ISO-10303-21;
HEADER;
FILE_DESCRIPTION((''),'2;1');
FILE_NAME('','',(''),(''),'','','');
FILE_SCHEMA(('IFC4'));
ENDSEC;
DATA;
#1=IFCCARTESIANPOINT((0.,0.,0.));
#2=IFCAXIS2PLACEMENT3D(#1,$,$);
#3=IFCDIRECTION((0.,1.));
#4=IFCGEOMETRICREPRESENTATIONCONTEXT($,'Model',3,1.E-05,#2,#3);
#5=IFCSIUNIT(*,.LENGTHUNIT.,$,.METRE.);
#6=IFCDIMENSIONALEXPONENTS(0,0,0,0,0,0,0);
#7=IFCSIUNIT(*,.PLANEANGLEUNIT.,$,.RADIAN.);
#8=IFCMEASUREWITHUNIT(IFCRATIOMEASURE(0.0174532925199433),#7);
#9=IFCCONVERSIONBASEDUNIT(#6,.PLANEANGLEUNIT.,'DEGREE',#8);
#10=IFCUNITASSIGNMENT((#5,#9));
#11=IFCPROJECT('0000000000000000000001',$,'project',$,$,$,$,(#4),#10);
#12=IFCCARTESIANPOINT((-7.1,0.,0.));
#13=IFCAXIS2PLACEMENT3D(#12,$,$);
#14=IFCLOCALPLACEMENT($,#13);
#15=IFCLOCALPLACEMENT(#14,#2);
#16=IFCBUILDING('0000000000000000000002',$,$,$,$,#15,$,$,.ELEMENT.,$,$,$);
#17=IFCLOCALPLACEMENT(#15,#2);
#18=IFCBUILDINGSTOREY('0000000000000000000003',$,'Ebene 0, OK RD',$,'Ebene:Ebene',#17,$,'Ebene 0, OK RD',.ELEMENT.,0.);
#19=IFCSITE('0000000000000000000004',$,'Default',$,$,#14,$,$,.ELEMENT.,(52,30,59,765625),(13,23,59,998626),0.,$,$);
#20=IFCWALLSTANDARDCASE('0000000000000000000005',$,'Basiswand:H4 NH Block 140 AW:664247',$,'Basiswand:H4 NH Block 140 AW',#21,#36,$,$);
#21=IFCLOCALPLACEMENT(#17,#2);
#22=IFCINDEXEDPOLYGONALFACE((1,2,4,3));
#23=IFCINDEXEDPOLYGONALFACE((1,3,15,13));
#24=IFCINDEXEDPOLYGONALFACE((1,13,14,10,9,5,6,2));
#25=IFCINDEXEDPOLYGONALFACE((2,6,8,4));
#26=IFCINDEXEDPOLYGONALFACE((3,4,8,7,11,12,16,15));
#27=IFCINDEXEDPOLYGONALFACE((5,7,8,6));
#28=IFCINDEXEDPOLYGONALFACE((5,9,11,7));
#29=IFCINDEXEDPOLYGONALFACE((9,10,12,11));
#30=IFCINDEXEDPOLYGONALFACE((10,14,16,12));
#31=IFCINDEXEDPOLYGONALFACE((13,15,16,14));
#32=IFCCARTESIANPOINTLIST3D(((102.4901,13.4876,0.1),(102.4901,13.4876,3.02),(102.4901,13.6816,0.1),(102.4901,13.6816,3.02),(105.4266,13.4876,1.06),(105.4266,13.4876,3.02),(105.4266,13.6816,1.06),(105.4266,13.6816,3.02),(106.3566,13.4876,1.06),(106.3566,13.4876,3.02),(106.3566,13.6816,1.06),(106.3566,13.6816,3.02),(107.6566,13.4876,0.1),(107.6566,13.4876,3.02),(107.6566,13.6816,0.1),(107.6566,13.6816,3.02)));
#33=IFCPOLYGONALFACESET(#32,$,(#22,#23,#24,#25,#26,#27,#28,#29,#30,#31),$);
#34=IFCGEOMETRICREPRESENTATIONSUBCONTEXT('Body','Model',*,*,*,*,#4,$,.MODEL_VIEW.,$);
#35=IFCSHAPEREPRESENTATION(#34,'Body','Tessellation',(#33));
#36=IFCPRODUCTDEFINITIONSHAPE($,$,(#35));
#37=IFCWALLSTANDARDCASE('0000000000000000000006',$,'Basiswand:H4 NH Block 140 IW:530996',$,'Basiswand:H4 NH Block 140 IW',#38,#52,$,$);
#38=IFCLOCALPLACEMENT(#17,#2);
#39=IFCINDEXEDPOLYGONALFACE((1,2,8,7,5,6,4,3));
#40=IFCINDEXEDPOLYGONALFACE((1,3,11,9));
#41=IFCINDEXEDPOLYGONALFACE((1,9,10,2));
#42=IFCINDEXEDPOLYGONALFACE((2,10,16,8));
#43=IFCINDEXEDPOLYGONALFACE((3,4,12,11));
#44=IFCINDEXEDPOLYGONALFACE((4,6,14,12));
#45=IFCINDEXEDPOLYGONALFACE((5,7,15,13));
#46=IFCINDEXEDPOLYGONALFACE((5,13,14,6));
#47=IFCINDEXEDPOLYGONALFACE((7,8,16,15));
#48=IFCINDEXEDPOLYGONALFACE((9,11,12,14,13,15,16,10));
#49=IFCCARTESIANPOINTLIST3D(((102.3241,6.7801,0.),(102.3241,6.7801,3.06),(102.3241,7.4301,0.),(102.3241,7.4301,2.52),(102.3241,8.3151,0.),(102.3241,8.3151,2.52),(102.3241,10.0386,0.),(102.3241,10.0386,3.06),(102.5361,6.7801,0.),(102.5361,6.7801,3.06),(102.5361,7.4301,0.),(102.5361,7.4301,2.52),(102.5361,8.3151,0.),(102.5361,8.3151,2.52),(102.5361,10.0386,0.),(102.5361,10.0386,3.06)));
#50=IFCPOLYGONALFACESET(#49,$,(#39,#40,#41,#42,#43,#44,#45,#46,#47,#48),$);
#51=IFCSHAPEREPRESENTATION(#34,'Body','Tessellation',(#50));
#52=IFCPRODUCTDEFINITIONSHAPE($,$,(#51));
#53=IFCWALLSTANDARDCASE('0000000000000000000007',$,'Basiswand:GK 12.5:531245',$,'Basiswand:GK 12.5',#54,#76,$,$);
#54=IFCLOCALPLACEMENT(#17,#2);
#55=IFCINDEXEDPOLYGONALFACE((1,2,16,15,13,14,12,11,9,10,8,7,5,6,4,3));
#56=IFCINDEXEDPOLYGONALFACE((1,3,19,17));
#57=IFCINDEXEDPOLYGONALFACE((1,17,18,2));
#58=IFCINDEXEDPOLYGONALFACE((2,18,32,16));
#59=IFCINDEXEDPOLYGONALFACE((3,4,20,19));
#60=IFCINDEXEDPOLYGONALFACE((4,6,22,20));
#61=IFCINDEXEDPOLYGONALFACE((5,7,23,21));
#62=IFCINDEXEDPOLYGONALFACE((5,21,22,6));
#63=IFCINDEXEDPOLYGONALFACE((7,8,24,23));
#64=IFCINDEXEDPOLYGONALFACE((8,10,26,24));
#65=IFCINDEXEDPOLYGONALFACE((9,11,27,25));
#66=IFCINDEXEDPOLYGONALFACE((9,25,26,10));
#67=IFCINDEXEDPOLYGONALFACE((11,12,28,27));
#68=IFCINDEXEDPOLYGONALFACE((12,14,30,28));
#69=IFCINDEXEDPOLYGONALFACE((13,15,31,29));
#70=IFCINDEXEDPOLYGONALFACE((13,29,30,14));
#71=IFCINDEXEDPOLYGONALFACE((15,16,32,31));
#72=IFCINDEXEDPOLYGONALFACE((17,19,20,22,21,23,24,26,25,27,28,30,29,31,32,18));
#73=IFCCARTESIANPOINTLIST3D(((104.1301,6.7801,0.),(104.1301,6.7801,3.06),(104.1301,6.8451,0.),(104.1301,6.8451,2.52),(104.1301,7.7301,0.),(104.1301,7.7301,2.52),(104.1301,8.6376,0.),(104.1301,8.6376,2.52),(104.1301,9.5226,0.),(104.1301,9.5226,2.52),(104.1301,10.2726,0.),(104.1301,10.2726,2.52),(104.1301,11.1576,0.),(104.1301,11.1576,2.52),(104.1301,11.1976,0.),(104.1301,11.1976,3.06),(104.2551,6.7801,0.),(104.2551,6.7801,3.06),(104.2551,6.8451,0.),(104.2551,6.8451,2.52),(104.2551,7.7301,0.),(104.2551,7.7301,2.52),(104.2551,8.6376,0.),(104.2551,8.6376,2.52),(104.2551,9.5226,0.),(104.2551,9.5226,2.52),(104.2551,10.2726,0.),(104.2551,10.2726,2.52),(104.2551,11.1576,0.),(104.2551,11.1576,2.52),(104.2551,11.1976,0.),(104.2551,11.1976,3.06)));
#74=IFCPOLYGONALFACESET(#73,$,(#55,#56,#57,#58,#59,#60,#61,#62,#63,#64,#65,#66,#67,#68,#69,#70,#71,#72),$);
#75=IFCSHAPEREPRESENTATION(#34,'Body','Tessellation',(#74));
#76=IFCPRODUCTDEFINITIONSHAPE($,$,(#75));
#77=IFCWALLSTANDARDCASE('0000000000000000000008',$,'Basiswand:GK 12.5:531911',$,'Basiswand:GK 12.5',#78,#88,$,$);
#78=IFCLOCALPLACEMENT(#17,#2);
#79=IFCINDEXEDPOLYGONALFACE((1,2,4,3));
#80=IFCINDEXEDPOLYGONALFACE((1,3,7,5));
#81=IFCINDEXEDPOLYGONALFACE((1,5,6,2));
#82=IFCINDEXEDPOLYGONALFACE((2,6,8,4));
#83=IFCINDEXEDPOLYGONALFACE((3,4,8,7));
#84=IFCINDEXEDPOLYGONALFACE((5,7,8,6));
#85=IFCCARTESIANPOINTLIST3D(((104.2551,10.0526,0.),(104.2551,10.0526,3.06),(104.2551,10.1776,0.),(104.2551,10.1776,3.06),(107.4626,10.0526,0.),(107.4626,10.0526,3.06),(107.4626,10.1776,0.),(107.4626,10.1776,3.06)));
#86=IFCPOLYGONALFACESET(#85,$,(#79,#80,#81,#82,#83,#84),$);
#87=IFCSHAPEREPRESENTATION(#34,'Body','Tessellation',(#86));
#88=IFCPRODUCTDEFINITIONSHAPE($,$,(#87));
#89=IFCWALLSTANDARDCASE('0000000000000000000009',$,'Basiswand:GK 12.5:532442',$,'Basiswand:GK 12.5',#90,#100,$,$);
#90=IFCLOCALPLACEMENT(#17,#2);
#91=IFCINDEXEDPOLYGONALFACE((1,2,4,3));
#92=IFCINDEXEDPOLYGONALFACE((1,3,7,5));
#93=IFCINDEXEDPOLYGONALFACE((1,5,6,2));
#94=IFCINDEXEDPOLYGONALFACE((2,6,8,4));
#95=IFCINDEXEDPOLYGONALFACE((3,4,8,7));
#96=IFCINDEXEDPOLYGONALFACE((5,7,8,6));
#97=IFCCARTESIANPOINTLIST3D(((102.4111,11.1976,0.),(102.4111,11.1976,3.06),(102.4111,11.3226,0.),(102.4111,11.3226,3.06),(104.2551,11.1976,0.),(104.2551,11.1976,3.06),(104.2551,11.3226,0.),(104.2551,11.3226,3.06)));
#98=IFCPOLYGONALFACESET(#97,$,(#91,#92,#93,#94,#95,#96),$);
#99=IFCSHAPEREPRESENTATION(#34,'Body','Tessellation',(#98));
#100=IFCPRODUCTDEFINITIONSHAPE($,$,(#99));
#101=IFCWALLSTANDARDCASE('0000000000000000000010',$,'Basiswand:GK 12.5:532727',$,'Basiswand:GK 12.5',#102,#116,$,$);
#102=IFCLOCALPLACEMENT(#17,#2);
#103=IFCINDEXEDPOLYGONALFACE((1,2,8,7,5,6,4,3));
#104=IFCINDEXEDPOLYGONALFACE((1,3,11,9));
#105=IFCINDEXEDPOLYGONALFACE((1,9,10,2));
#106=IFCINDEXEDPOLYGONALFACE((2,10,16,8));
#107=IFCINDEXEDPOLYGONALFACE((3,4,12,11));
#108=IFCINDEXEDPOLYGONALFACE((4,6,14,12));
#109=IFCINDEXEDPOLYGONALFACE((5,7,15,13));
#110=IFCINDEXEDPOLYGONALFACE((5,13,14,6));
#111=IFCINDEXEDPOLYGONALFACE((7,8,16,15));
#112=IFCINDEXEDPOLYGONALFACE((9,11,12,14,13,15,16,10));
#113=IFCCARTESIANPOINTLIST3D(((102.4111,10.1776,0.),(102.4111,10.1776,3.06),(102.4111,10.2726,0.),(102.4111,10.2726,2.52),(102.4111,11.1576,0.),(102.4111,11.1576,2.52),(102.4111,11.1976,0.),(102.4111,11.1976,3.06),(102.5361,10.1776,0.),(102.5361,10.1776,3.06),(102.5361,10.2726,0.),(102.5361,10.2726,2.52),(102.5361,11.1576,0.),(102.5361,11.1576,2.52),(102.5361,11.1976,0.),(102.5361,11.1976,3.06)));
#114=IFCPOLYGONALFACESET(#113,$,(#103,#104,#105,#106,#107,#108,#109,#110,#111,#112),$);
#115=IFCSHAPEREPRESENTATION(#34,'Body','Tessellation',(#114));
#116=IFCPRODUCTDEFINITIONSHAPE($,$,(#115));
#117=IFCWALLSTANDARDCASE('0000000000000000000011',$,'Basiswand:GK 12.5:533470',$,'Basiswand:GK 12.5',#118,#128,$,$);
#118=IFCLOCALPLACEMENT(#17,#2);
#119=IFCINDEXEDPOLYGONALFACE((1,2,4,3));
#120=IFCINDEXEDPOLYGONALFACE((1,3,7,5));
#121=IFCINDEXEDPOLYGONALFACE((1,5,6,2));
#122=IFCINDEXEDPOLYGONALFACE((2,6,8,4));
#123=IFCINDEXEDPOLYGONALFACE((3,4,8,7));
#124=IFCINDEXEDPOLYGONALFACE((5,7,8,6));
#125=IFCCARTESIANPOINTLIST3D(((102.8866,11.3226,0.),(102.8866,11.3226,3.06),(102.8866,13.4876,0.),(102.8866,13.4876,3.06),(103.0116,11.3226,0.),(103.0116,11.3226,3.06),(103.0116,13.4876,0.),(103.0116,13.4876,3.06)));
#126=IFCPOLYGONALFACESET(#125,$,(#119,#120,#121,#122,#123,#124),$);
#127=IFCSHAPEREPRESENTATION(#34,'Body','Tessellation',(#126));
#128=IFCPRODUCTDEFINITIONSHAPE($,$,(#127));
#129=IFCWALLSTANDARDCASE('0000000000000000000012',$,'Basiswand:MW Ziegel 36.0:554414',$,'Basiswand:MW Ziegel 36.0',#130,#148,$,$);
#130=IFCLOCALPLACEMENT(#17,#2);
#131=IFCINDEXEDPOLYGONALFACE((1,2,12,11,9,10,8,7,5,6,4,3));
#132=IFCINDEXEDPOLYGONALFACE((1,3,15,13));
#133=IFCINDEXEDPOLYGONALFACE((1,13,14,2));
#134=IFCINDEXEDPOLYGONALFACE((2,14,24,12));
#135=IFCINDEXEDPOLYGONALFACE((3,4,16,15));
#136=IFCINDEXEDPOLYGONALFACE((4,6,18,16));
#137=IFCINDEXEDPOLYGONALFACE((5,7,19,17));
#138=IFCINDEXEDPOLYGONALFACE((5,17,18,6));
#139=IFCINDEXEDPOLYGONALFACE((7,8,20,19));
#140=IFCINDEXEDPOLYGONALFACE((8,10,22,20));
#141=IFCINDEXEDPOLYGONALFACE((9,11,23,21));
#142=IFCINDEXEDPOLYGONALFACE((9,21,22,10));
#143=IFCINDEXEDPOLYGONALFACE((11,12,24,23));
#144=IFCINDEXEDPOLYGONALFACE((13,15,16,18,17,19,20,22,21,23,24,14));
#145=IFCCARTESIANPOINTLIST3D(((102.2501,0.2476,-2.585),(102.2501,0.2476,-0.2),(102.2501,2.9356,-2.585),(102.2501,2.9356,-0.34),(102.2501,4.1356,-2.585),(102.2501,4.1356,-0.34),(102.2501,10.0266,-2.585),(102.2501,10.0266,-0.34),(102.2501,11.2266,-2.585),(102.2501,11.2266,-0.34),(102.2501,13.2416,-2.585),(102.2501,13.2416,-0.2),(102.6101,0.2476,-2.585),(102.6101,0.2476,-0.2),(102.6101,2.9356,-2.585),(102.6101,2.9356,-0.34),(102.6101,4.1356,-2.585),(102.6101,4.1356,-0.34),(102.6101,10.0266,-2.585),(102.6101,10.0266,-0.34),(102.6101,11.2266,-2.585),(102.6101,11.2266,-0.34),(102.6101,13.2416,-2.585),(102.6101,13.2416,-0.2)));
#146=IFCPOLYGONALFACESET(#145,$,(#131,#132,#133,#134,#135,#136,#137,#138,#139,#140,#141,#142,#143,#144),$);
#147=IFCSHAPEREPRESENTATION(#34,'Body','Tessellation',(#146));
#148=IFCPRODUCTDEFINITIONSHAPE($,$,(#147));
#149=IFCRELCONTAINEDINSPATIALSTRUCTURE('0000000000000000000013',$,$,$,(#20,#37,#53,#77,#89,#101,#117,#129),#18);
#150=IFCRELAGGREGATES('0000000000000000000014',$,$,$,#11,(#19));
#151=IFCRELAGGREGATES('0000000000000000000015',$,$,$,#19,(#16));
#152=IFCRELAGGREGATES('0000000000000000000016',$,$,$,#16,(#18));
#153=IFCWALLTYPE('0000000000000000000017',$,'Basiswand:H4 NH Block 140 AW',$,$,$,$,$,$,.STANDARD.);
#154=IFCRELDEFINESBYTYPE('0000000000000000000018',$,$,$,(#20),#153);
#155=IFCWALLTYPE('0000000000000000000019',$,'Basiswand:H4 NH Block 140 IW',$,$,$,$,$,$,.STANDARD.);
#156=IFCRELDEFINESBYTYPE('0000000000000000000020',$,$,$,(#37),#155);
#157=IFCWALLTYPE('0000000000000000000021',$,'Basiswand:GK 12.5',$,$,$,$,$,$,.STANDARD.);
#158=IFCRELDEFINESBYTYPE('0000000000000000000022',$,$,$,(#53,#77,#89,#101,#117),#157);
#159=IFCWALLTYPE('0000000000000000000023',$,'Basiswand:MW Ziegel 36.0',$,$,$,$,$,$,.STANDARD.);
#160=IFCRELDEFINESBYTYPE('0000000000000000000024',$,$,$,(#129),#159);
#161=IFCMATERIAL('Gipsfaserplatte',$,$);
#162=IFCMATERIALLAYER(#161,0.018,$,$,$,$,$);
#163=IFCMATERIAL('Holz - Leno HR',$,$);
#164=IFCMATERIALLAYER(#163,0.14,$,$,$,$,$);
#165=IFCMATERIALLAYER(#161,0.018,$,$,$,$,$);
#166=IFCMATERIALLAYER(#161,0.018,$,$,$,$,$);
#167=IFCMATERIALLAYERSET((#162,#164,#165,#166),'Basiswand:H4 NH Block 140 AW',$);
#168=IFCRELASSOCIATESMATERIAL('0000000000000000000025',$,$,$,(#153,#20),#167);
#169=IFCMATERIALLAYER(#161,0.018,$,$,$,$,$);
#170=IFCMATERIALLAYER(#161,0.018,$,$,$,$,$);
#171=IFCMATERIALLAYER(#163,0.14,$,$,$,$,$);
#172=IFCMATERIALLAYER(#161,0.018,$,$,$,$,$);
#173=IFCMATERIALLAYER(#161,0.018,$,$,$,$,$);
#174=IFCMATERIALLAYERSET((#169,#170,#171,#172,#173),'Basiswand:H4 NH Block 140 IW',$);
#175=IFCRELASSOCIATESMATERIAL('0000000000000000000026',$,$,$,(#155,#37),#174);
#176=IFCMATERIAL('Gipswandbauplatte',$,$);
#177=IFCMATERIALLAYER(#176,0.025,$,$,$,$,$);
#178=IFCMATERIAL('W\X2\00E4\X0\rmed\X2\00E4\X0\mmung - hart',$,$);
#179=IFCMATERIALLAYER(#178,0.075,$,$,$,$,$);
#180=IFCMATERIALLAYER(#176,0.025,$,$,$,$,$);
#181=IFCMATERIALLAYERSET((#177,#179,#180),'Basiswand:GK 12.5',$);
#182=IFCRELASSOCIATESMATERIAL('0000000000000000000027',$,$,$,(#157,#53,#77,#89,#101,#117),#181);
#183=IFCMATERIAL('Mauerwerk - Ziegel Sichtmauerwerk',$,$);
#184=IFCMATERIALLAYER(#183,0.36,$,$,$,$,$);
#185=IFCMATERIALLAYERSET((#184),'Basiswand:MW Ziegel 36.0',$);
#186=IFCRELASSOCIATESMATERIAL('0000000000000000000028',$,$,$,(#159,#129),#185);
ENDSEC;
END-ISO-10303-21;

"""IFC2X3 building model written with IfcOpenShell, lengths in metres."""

from ifc_helpers import new_model, entity, si_unit, converted_unit, direction, frame, frame_2d, origin, origin_2d_with_axis, place, context, subcontext, project, spatial, rectangle, extrude, material, layer, layer_set, layer_usage, type_object, element, save


model = new_model("IFC2X3")

# Units and contexts
model_context = context("Model", 3, precision=1e-05, world=origin(), true_north=direction((0.0, 1.0)))
body_context = subcontext(model_context, "Body", "Model", "MODEL_VIEW")
ifc_project = project(units=[si_unit("LENGTHUNIT", "METRE"), converted_unit("PLANEANGLEUNIT", "DEGREE", entity("IfcRatioMeasure", 0.0174532925199433), si_unit("PLANEANGLEUNIT", "RADIAN"), dimensions=[0, 0, 0, 0, 0, 0, 0])], contexts=[model_context])

# Site, building, storey
site_placement = place(None, frame((-7.1, 0.0, 0.0)))
site = spatial("IfcSite", under=ifc_project, at=site_placement, Name="Default", CompositionType="ELEMENT", RefLatitude=(52, 30, 59, 765625), RefLongitude=(13, 23, 59, 998626), RefElevation=0.0)
building_placement = place(site_placement, origin())
building = spatial("IfcBuilding", under=site, at=building_placement, CompositionType="ELEMENT")
storey_placement = place(building_placement, origin())
storey = spatial("IfcBuildingStorey", under=building, at=storey_placement, Name="Ebene 0, OK RD", ObjectType="Ebene:Ebene", LongName="Ebene 0, OK RD", CompositionType="ELEMENT", Elevation=0.0)

# Walls, openings
ifc_material_1 = material(Name="Gipsfaserplatte")
ifc_layer_1 = layer(ifc_material_1, 0.018)
ifc_material_2 = material(Name="Holz - Leno HR")
ifc_layer_2 = layer(ifc_material_2, 0.14)
ifc_layer_3 = layer(ifc_material_1, 0.018)
ifc_layer_4 = layer(ifc_material_1, 0.018)
ifc_layer_set_1 = layer_set([ifc_layer_1, ifc_layer_2, ifc_layer_3, ifc_layer_4], Name="Basiswand:H4 NH Block 140 AW")
ifc_layer_usage_1 = layer_usage(ifc_layer_set_1, "AXIS2", "NEGATIVE", 0.097)
wall_type_1 = type_object("IfcWallType", Name="Basiswand:H4 NH Block 140 AW", PredefinedType="STANDARD", material=ifc_layer_set_1)
wall_1_placement = place(storey_placement, frame((102.4901, 13.5846, 0.1)))
wall_1 = element("IfcWallStandardCase", 1, at=wall_1_placement, inside=storey, type_object=wall_type_1, material=ifc_layer_usage_1, Name="Basiswand:H4 NH Block 140 AW:664247", ObjectType="Basiswand:H4 NH Block 140 AW", context=body_context, shape_type="SweptSolid", body=[
    extrude(rectangle(XDim=5.1665, YDim=0.194, at=frame_2d((2.5833, 0.0), x_axis=(-1.0, 0.0))), origin(), (0.0, 0.0, 1.0), 2.92),
])
opening_1_placement = place(wall_1_placement, origin())
element("IfcOpeningElement", 2, at=opening_1_placement, cuts=wall_1, ObjectType="Opening", context=body_context, shape_type="SweptSolid", body=[
    extrude(rectangle(XDim=2.0, YDim=0.93, at=frame_2d((0.0, 0.0), x_axis=(1.0, 0.0))), frame((3.4015, -0.097, 1.96), z_axis=(0.0, 1.0, 0.0), x_axis=(0.0, 0.0, -1.0)), (0.0, 0.0, 1.0), 0.194),
])
ifc_layer_5 = layer(ifc_material_1, 0.018)
ifc_layer_6 = layer(ifc_material_1, 0.018)
ifc_layer_7 = layer(ifc_material_2, 0.14)
ifc_layer_8 = layer(ifc_material_1, 0.018)
ifc_layer_9 = layer(ifc_material_1, 0.018)
ifc_layer_set_2 = layer_set([ifc_layer_5, ifc_layer_6, ifc_layer_7, ifc_layer_8, ifc_layer_9], Name="Basiswand:H4 NH Block 140 IW")
ifc_layer_usage_2 = layer_usage(ifc_layer_set_2, "AXIS2", "NEGATIVE", 0.106)
wall_type_2 = type_object("IfcWallType", Name="Basiswand:H4 NH Block 140 IW", PredefinedType="STANDARD", material=ifc_layer_set_2)
wall_2_placement = place(storey_placement, frame((102.4301, 10.0386, 0.0), z_axis=(0.0, 0.0, 1.0), x_axis=(0.0, -1.0, 0.0)))
wall_2 = element("IfcWallStandardCase", 3, at=wall_2_placement, inside=storey, type_object=wall_type_2, material=ifc_layer_usage_2, Name="Basiswand:H4 NH Block 140 IW:530996", ObjectType="Basiswand:H4 NH Block 140 IW", context=body_context, shape_type="SweptSolid", body=[
    extrude(rectangle(XDim=3.2585, YDim=0.212, at=frame_2d((1.6292, 0.0), x_axis=(-1.0, 0.0))), origin(), (0.0, 0.0, 1.0), 3.06),
])
opening_2_placement = place(wall_2_placement, frame((2.6085, 0.106, 0.0)))
element("IfcOpeningElement", 4, at=opening_2_placement, cuts=wall_2, ObjectType="Opening", context=body_context, shape_type="SweptSolid", body=[
    extrude(rectangle(XDim=2.52, YDim=0.885, at=frame_2d((1.26, 0.4425), x_axis=(1.0, 0.0))), frame((0.0, 0.0, 0.0), z_axis=(0.0, -1.0, 0.0), x_axis=(0.0, 0.0, 1.0)), (0.0, 0.0, 1.0), 0.212),
])

# Wall, openings
ifc_material_3 = material(Name="Gipswandbauplatte")
ifc_layer_10 = layer(ifc_material_3, 0.025)
ifc_material_4 = material(Name="Wärmedämmung - hart")
ifc_layer_11 = layer(ifc_material_4, 0.075)
ifc_layer_12 = layer(ifc_material_3, 0.025)
ifc_layer_set_3 = layer_set([ifc_layer_10, ifc_layer_11, ifc_layer_12], Name="Basiswand:GK 12.5")
ifc_layer_usage_3 = layer_usage(ifc_layer_set_3, "AXIS2", "NEGATIVE", 0.0625)
wall_type_3 = type_object("IfcWallType", Name="Basiswand:GK 12.5", PredefinedType="STANDARD", material=ifc_layer_set_3)
wall_3_placement = place(storey_placement, frame((104.1926, 11.1976, 0.0), z_axis=(0.0, 0.0, 1.0), x_axis=(0.0, -1.0, 0.0)))
wall_3 = element("IfcWallStandardCase", 5, at=wall_3_placement, inside=storey, type_object=wall_type_3, material=ifc_layer_usage_3, Name="Basiswand:GK 12.5:531245", ObjectType="Basiswand:GK 12.5", context=body_context, shape_type="SweptSolid", body=[
    extrude(rectangle(XDim=4.4175, YDim=0.125, at=frame_2d((2.2088, 0.0), x_axis=(-1.0, 0.0))), origin(), (0.0, 0.0, 1.0), 3.06),
])
opening_3_placement = place(wall_3_placement, frame((0.04, -0.0625, 0.0)))
element("IfcOpeningElement", 6, at=opening_3_placement, cuts=wall_3, ObjectType="Opening", context=body_context, shape_type="SweptSolid", body=[
    extrude(rectangle(XDim=2.52, YDim=0.885, at=frame_2d((1.26, 0.4425), x_axis=(1.0, 0.0))), frame((0.0, 0.0, 0.0), z_axis=(0.0, 1.0, 0.0), x_axis=(0.0, 0.0, 1.0)), (0.0, 0.0, 1.0), 0.125),
])
opening_4_placement = place(wall_3_placement, frame((1.675, -0.0625, 0.0)))
element("IfcOpeningElement", 7, at=opening_4_placement, cuts=wall_3, ObjectType="Opening", context=body_context, shape_type="SweptSolid", body=[
    extrude(rectangle(XDim=2.52, YDim=0.885, at=frame_2d((1.26, 0.4425), x_axis=(1.0, 0.0))), frame((0.0, 0.0, 0.0), z_axis=(0.0, 1.0, 0.0), x_axis=(0.0, 0.0, 1.0)), (0.0, 0.0, 1.0), 0.125),
])
opening_5_placement = place(wall_3_placement, frame((3.4675, -0.0625, 0.0)))
element("IfcOpeningElement", 8, at=opening_5_placement, cuts=wall_3, ObjectType="Opening", context=body_context, shape_type="SweptSolid", body=[
    extrude(rectangle(XDim=2.52, YDim=0.885, at=frame_2d((1.26, 0.4425), x_axis=(1.0, 0.0))), frame((0.0, 0.0, 0.0), z_axis=(0.0, 1.0, 0.0), x_axis=(0.0, 0.0, 1.0)), (0.0, 0.0, 1.0), 0.125),
])

# Walls
ifc_layer_usage_4 = layer_usage(ifc_layer_set_3, "AXIS2", "NEGATIVE", 0.0625)
wall_4_placement = place(storey_placement, frame((104.2551, 10.1151, 0.0)))
element("IfcWallStandardCase", 9, at=wall_4_placement, inside=storey, type_object=wall_type_3, material=ifc_layer_usage_4, Name="Basiswand:GK 12.5:531911", ObjectType="Basiswand:GK 12.5", context=body_context, shape_type="SweptSolid", body=[
    extrude(rectangle(XDim=3.2075, YDim=0.125, at=frame_2d((1.6038, 0.0), x_axis=(-1.0, 0.0))), origin(), (0.0, 0.0, 1.0), 3.06),
])
ifc_layer_usage_5 = layer_usage(ifc_layer_set_3, "AXIS2", "NEGATIVE", 0.0625)
wall_5_placement = place(storey_placement, frame((102.4111, 11.2601, 0.0)))
element("IfcWallStandardCase", 10, at=wall_5_placement, inside=storey, type_object=wall_type_3, material=ifc_layer_usage_5, Name="Basiswand:GK 12.5:532442", ObjectType="Basiswand:GK 12.5", context=body_context, shape_type="SweptSolid", body=[
    extrude(rectangle(XDim=1.844, YDim=0.125, at=frame_2d((0.922, 0.0), x_axis=(-1.0, 0.0))), origin(), (0.0, 0.0, 1.0), 3.06),
])

# Wall, opening
ifc_layer_usage_6 = layer_usage(ifc_layer_set_3, "AXIS2", "NEGATIVE", 0.0625)
wall_6_placement = place(storey_placement, frame((102.4736, 11.1976, 0.0), z_axis=(0.0, 0.0, 1.0), x_axis=(0.0, -1.0, 0.0)))
wall_6 = element("IfcWallStandardCase", 11, at=wall_6_placement, inside=storey, type_object=wall_type_3, material=ifc_layer_usage_6, Name="Basiswand:GK 12.5:532727", ObjectType="Basiswand:GK 12.5", context=body_context, shape_type="SweptSolid", body=[
    extrude(rectangle(XDim=1.02, YDim=0.125, at=frame_2d((0.51, 0.0), x_axis=(-1.0, 0.0))), origin(), (0.0, 0.0, 1.0), 3.06),
])
opening_6_placement = place(wall_6_placement, frame((0.925, 0.0625, 0.0)))
element("IfcOpeningElement", 12, at=opening_6_placement, cuts=wall_6, ObjectType="Opening", context=body_context, shape_type="SweptSolid", body=[
    extrude(rectangle(XDim=2.52, YDim=0.885, at=frame_2d((1.26, 0.4425), x_axis=(1.0, 0.0))), frame((0.0, 0.0, 0.0), z_axis=(0.0, -1.0, 0.0), x_axis=(0.0, 0.0, 1.0)), (0.0, 0.0, 1.0), 0.125),
])

# Wall
ifc_layer_usage_7 = layer_usage(ifc_layer_set_3, "AXIS2", "NEGATIVE", 0.0625)
wall_7_placement = place(storey_placement, frame((102.9491, 11.3226, 0.0), z_axis=(0.0, 0.0, 1.0), x_axis=(0.0, 1.0, 0.0)))
element("IfcWallStandardCase", 13, at=wall_7_placement, inside=storey, type_object=wall_type_3, material=ifc_layer_usage_7, Name="Basiswand:GK 12.5:533470", ObjectType="Basiswand:GK 12.5", context=body_context, shape_type="SweptSolid", body=[
    extrude(rectangle(XDim=2.165, YDim=0.125, at=frame_2d((1.0825, 0.0), x_axis=(-1.0, 0.0))), origin(), (0.0, 0.0, 1.0), 3.06),
])

# Wall, openings
ifc_material_5 = material(Name="Mauerwerk - Ziegel Sichtmauerwerk")
ifc_layer_13 = layer(ifc_material_5, 0.36)
ifc_layer_set_4 = layer_set([ifc_layer_13], Name="Basiswand:MW Ziegel 36.0")
ifc_layer_usage_8 = layer_usage(ifc_layer_set_4, "AXIS2", "NEGATIVE", 0.18)
wall_type_4 = type_object("IfcWallType", Name="Basiswand:MW Ziegel 36.0", PredefinedType="STANDARD", material=ifc_layer_set_4)
wall_8_placement = place(storey_placement, frame((102.4301, 13.2416, -2.585), z_axis=(0.0, 0.0, 1.0), x_axis=(0.0, -1.0, 0.0)))
wall_8 = element("IfcWallStandardCase", 14, at=wall_8_placement, inside=storey, type_object=wall_type_4, material=ifc_layer_usage_8, Name="Basiswand:MW Ziegel 36.0:554414", ObjectType="Basiswand:MW Ziegel 36.0", context=body_context, shape_type="SweptSolid", body=[
    extrude(rectangle(XDim=12.994, YDim=0.36, at=frame_2d((6.497, 0.0), x_axis=(-1.0, 0.0))), origin(), (0.0, 0.0, 1.0), 2.385),
])
opening_7_placement = place(wall_8_placement, origin())
element("IfcOpeningElement", 15, at=opening_7_placement, cuts=wall_8, ObjectType="Opening", context=body_context, shape_type="SweptSolid", body=[
    extrude(rectangle(XDim=2.245, YDim=1.2, at=origin_2d_with_axis()), frame((2.615, -0.18, 1.1225), z_axis=(0.0, 1.0, 0.0), x_axis=(0.0, 0.0, -1.0)), (0.0, 0.0, 1.0), 0.36),
])
opening_8_placement = place(wall_8_placement, origin())
element("IfcOpeningElement", 16, at=opening_8_placement, cuts=wall_8, ObjectType="Opening", context=body_context, shape_type="SweptSolid", body=[
    extrude(rectangle(XDim=2.245, YDim=1.2, at=origin_2d_with_axis()), frame((9.706, -0.18, 1.1225), z_axis=(0.0, 1.0, 0.0), x_axis=(0.0, 0.0, -1.0)), (0.0, 0.0, 1.0), 0.36),
])

save(model, "model.ifc")
